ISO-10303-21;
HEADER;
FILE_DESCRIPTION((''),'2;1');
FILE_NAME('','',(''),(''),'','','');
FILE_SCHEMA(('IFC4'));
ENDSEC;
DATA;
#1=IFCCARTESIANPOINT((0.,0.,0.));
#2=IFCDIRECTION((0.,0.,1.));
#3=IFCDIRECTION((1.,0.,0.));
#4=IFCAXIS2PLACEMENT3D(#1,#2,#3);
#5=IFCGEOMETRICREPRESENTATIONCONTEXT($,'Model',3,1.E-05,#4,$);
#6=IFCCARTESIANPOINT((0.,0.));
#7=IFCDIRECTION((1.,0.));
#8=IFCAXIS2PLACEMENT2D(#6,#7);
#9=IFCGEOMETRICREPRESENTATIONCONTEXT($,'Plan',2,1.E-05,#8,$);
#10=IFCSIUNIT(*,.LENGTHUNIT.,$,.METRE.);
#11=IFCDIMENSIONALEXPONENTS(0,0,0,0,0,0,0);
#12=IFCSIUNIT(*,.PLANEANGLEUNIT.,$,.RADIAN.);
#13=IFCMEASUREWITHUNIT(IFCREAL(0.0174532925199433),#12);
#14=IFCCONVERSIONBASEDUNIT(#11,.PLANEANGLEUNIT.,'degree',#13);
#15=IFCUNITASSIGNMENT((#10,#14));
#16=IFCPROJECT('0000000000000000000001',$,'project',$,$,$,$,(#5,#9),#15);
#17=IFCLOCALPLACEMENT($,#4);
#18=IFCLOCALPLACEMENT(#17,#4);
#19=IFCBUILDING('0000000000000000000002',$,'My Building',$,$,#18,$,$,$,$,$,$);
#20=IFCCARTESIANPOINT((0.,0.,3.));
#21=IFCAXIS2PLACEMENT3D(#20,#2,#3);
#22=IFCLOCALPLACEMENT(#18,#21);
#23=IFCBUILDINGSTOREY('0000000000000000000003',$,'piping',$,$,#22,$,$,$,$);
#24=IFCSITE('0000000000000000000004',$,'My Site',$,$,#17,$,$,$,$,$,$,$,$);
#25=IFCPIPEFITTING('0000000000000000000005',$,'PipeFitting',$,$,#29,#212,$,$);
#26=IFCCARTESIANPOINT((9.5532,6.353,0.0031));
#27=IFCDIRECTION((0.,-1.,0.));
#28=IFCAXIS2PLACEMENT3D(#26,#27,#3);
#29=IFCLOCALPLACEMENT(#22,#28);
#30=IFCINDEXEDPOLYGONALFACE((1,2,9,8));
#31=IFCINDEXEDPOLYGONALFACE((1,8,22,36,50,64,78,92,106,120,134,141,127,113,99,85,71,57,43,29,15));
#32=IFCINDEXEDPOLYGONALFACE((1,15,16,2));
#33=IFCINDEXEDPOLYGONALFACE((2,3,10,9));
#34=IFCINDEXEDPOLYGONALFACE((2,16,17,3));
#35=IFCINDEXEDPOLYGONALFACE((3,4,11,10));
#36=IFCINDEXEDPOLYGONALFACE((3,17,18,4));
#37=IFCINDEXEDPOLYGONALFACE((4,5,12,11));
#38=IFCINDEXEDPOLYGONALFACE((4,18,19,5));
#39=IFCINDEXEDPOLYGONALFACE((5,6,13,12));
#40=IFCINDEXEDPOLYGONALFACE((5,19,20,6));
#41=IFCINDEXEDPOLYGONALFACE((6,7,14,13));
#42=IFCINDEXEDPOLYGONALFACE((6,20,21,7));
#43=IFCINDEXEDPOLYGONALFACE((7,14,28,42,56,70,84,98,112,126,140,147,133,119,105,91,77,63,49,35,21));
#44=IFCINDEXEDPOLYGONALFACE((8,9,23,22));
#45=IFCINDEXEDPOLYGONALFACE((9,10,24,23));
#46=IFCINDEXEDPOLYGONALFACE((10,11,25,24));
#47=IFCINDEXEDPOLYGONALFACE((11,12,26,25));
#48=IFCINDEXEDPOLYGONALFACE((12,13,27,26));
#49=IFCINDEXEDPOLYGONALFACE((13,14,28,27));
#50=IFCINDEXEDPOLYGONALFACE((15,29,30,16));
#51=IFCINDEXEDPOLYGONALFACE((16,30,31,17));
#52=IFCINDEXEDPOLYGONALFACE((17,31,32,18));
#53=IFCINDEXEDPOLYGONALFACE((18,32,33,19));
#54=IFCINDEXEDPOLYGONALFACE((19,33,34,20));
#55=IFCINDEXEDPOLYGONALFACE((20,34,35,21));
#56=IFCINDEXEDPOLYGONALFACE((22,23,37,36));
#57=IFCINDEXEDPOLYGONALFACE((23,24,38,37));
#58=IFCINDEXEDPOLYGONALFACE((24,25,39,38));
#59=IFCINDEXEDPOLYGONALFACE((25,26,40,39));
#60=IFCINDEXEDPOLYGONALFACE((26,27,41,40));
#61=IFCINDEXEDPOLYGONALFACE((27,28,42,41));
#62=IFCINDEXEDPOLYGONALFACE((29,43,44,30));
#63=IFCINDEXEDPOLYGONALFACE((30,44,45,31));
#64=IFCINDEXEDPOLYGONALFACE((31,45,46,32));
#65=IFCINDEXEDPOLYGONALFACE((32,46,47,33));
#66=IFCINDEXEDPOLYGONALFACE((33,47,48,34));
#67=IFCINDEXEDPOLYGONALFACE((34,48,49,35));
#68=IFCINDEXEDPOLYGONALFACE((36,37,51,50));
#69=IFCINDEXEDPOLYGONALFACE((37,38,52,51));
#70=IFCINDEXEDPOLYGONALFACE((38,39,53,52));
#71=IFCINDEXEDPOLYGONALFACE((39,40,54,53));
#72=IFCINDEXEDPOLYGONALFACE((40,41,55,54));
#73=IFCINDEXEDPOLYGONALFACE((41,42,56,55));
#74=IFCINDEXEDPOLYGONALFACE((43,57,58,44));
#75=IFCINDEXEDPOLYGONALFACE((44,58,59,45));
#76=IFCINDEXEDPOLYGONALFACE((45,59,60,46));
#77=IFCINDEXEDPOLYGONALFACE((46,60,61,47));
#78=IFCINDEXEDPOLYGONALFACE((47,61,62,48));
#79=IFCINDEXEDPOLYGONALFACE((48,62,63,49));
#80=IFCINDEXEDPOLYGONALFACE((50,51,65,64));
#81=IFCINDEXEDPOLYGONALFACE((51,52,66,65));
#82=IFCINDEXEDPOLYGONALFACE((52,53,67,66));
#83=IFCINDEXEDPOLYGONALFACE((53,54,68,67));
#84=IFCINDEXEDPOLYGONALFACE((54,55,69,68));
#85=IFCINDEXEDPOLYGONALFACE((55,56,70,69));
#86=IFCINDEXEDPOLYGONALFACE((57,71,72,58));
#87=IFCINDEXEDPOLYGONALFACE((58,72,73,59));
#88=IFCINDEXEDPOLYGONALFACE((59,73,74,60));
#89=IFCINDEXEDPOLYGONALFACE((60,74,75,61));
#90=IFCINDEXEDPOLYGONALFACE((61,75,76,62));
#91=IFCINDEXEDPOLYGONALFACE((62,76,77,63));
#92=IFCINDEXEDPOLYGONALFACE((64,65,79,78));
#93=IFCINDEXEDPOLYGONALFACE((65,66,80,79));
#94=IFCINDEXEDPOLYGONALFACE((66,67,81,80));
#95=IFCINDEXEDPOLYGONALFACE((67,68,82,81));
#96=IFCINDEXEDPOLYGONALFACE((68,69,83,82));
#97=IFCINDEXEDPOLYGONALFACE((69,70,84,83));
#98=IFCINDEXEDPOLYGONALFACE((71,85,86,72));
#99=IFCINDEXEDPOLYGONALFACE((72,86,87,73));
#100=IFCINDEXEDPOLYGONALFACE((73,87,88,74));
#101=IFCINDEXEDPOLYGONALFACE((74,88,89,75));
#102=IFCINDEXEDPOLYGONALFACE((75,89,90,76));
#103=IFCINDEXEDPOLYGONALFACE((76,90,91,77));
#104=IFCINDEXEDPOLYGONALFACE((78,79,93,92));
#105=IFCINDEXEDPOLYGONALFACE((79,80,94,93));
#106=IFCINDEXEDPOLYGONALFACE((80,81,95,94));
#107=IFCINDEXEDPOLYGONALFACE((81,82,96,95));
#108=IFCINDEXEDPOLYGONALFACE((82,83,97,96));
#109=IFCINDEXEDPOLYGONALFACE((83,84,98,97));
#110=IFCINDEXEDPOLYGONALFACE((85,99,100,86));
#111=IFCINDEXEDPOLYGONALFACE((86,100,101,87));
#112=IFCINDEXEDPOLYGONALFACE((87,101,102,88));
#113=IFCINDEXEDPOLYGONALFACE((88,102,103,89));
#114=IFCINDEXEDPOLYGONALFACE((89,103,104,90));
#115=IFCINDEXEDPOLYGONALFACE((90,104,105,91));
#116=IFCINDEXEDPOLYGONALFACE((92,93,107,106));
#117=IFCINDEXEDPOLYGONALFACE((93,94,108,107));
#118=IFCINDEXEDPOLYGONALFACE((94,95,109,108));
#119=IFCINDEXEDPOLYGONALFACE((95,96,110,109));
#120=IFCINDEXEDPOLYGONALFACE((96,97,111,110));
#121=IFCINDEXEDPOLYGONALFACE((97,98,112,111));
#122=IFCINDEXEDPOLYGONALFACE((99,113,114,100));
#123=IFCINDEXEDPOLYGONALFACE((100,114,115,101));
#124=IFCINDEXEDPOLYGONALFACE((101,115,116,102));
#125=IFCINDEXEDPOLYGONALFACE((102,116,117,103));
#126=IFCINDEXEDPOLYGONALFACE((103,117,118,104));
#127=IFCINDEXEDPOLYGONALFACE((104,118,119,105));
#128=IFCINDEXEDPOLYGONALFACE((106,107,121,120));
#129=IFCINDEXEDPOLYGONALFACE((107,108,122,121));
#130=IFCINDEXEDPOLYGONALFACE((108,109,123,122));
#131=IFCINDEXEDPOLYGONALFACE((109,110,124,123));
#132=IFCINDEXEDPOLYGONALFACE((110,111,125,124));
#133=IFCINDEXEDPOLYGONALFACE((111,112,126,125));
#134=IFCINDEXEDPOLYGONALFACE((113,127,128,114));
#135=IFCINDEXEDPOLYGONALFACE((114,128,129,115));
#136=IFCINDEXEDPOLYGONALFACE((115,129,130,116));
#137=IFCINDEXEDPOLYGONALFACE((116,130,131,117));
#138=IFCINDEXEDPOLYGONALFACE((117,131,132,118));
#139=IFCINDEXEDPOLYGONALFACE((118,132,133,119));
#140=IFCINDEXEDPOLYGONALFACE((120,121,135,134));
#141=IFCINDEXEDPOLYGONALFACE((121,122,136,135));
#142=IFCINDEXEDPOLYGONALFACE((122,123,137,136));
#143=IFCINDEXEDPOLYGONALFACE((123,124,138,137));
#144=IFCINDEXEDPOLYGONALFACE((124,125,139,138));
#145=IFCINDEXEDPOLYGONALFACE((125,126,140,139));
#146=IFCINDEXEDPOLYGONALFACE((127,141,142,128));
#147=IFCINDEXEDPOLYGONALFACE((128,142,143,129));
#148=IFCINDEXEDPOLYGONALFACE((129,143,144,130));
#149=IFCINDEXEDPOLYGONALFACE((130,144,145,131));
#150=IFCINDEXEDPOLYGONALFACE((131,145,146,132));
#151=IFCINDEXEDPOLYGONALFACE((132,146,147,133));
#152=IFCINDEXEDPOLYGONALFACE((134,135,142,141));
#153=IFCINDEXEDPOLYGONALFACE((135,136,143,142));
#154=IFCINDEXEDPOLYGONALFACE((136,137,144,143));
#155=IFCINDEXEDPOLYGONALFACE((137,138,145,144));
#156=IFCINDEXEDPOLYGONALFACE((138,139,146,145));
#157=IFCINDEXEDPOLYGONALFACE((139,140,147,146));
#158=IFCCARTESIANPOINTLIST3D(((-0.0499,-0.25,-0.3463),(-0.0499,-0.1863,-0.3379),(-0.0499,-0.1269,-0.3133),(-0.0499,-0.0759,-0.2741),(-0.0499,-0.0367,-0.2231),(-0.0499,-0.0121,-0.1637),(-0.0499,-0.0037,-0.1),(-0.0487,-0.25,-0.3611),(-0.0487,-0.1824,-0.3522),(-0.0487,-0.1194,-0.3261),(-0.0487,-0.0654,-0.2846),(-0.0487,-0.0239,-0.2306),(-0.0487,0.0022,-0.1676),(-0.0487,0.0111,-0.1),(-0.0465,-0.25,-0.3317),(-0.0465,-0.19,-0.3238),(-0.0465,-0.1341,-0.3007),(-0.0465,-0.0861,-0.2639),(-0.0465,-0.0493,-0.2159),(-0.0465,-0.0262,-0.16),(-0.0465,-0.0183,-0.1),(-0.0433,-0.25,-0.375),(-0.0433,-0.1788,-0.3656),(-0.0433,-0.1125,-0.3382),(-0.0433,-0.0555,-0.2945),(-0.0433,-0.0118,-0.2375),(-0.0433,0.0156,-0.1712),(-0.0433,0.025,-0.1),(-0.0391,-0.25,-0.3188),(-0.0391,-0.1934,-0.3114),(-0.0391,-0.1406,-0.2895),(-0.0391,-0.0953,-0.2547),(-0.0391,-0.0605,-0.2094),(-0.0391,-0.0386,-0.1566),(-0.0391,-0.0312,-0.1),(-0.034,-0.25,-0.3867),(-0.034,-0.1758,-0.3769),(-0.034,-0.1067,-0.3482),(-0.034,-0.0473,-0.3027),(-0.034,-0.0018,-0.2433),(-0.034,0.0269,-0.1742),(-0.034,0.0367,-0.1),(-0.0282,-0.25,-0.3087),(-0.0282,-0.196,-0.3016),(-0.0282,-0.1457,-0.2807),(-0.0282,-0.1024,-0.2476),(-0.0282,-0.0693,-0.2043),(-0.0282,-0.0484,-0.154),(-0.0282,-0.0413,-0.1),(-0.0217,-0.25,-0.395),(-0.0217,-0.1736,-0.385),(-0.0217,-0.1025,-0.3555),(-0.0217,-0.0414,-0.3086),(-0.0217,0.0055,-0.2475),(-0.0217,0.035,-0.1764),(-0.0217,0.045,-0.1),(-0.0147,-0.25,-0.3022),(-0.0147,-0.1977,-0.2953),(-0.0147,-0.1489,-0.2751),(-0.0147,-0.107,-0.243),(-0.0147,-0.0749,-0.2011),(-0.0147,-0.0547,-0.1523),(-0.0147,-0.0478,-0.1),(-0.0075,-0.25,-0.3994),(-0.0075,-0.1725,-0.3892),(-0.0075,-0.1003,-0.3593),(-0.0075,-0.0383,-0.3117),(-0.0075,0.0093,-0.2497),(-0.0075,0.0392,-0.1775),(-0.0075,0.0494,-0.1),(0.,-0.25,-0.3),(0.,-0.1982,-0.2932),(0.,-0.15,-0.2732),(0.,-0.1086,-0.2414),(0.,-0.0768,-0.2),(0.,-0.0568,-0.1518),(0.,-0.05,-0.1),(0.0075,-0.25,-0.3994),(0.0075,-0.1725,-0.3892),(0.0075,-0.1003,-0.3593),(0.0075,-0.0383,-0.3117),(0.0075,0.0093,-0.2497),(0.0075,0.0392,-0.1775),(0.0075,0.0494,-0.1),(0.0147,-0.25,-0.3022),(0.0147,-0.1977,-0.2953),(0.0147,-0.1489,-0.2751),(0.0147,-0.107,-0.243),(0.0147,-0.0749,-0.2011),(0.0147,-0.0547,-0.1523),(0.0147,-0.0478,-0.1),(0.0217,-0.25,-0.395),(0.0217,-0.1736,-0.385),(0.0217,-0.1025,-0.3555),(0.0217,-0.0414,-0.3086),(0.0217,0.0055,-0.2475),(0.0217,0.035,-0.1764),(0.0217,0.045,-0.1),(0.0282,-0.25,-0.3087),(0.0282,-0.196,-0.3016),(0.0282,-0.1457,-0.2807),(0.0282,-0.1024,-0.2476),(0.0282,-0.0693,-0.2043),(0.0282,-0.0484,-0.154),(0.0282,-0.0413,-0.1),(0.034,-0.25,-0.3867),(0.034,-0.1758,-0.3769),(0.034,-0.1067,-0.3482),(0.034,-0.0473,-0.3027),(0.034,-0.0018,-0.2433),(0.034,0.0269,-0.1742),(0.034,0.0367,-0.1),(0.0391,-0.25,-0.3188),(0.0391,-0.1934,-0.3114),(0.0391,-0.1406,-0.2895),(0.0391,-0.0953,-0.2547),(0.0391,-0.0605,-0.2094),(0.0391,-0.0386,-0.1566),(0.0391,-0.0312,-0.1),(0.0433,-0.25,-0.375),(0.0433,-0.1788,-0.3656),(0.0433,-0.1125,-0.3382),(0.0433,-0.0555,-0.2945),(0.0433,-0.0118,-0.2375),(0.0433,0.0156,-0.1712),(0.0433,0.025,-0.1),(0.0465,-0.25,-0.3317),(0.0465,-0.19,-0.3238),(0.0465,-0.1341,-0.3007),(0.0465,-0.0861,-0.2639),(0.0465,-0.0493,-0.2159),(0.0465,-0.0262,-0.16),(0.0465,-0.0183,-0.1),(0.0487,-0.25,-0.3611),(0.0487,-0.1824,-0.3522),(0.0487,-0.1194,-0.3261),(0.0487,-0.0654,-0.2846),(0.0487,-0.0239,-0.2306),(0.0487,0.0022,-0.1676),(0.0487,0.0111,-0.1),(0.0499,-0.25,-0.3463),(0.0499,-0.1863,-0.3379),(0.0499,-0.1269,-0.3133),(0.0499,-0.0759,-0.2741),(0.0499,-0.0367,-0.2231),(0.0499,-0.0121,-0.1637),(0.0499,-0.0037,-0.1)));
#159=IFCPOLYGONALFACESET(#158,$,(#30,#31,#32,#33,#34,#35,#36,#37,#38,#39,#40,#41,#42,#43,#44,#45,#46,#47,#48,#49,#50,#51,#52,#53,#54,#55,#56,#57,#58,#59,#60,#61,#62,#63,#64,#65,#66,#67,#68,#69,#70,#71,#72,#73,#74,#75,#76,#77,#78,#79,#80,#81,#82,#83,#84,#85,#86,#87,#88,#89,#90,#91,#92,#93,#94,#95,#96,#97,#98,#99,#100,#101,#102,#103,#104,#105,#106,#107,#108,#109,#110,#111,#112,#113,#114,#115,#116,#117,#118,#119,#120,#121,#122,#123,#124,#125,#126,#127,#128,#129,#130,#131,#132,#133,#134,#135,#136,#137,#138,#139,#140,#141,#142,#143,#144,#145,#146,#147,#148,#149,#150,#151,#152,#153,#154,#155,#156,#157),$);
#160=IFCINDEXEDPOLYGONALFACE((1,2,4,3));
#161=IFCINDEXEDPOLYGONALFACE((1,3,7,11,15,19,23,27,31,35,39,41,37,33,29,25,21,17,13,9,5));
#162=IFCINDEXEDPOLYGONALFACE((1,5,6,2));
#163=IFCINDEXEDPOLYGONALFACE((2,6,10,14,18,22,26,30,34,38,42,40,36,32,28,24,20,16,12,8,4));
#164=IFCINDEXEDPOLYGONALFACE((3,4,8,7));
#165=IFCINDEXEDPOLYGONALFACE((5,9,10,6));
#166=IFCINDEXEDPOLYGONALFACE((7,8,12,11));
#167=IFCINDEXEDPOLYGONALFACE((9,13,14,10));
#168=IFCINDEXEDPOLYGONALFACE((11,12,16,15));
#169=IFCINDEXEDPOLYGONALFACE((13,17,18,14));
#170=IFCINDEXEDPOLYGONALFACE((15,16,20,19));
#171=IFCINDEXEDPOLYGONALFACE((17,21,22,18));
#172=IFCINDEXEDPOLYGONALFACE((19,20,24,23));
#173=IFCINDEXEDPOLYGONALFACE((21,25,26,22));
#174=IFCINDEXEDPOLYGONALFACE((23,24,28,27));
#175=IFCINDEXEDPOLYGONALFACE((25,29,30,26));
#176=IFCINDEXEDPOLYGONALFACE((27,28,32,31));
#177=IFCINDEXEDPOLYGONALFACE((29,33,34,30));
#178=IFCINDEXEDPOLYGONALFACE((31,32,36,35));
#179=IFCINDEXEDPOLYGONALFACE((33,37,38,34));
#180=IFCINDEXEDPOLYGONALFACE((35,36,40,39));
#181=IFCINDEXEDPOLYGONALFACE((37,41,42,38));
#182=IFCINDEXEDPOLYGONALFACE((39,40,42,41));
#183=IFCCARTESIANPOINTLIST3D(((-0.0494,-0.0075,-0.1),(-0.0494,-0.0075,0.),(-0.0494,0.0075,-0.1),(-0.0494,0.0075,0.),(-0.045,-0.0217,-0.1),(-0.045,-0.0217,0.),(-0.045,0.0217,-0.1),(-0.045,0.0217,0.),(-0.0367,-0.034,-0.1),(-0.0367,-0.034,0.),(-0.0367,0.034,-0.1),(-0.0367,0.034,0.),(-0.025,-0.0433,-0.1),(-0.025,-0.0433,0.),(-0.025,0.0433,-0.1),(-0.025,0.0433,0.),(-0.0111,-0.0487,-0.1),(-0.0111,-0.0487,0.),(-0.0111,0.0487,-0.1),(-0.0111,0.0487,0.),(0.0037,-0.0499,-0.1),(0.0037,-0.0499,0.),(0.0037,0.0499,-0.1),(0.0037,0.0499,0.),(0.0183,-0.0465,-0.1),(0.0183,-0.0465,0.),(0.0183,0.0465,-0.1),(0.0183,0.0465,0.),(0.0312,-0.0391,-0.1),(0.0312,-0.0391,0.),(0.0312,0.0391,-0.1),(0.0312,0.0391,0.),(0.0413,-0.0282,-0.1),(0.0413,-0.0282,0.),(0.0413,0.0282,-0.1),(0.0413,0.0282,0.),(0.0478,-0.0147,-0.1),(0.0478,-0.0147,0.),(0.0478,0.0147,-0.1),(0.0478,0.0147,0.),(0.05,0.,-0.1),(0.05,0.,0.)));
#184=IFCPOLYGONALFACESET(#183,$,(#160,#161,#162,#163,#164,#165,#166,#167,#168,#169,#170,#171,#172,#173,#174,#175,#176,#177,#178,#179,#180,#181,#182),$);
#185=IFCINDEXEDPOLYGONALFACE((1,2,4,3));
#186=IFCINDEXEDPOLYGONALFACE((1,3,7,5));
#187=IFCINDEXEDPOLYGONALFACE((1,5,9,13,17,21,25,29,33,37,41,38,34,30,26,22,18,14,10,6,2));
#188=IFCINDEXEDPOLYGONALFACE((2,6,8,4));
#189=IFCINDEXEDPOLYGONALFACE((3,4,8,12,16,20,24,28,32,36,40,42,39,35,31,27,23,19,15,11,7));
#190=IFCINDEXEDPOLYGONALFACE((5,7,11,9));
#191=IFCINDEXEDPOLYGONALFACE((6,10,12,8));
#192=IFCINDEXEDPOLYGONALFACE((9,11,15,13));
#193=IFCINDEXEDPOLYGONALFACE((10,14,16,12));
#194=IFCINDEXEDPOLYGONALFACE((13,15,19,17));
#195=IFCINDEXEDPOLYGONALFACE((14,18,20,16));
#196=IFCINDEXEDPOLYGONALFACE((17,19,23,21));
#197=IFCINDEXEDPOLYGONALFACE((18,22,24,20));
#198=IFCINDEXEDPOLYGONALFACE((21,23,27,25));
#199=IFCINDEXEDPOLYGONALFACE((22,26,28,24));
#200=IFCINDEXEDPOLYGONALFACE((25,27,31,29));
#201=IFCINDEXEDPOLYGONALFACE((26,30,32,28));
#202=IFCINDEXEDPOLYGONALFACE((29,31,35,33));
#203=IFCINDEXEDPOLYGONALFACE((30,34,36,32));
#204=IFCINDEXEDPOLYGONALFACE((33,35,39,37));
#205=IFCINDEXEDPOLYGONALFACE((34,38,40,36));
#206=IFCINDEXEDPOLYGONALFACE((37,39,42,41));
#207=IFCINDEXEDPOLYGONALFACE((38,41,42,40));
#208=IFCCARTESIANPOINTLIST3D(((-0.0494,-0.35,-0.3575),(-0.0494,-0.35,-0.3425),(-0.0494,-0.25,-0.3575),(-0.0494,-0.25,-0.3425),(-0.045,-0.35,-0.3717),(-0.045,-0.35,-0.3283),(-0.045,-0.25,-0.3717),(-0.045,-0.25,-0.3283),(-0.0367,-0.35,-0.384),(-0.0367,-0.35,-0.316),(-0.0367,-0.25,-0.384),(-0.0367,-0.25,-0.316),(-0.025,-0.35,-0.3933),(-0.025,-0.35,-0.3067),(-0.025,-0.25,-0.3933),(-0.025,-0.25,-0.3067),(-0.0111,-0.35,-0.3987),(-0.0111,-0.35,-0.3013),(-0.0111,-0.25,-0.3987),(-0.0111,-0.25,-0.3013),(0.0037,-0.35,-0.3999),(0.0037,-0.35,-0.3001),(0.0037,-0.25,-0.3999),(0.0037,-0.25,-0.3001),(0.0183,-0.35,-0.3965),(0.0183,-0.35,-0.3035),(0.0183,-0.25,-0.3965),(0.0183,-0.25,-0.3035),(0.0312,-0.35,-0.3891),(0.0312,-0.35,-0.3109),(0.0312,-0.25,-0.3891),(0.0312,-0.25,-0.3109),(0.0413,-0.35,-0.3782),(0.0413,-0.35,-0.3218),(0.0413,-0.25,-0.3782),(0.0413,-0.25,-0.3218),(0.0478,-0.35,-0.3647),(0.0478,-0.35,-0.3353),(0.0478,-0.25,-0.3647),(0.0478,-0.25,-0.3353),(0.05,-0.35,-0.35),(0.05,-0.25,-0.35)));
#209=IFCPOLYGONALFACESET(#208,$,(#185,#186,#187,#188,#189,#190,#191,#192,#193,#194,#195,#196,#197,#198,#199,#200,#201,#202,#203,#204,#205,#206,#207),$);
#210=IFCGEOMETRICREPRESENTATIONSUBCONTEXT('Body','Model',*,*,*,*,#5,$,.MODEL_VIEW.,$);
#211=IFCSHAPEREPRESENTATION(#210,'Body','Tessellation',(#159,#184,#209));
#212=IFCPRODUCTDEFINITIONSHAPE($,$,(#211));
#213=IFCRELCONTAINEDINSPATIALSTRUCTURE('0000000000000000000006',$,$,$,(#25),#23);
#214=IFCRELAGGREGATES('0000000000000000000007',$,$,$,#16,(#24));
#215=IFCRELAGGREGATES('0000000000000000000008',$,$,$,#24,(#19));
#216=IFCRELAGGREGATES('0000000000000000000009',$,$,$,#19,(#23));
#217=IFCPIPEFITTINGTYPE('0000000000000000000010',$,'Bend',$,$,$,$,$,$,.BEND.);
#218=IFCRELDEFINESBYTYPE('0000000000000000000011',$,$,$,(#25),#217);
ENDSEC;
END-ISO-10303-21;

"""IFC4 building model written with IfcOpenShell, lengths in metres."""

from ifc_helpers import new_model, entity, si_unit, converted_unit, frame, origin_with_axes, origin_2d_with_axis, place, context, subcontext, project, spatial, circle, extrude, source, transform, mapped, type_object, type_shapes, element, save


model = new_model("IFC4")

# Units and contexts
model_context = context("Model", 3, precision=1e-05, world=origin_with_axes())
plan_context = context("Plan", 2, precision=1e-05, world=origin_2d_with_axis())
body_context = subcontext(model_context, "Body", "Model", "MODEL_VIEW")
ifc_project = project(units=[si_unit("LENGTHUNIT", "METRE"), converted_unit("PLANEANGLEUNIT", "degree", entity("IfcReal", 0.0174532925199433), si_unit("PLANEANGLEUNIT", "RADIAN"), dimensions=[0, 0, 0, 0, 0, 0, 0])], contexts=[model_context, plan_context])

# Site, building, storey
site_placement = place(None, origin_with_axes())
site = spatial("IfcSite", under=ifc_project, at=site_placement, Name="My Site")
building_placement = place(site_placement, origin_with_axes())
building = spatial("IfcBuilding", under=site, at=building_placement, Name="My Building")
storey_placement = place(building_placement, frame((0.0, 0.0, 3.0), z_axis=(0.0, 0.0, 1.0), x_axis=(1.0, 0.0, 0.0)))
storey = spatial("IfcBuildingStorey", under=building, at=storey_placement, Name="piping")

# Pipe fitting
pipe_fitting_type = type_object("IfcPipeFittingType", Name="Bend", PredefinedType="BEND")
shared_shape = source(origin_with_axes(), body_context, "Body", "SolidModel", [
    entity("IfcSweptDiskSolid", entity("IfcIndexedPolyCurve", entity("IfcCartesianPointList3D", [[0.0, 0.0, -0.1], [0.0, -0.0732, -0.2768], [0.0, -0.25, -0.35]]), [entity("IfcArcIndex", [1, 2, 3])]), 0.05),
    extrude(circle(Radius=0.05), origin_with_axes(), (0.0, 0.0, -1.0), 0.1),
    extrude(circle(Radius=0.05), frame((0.0, -0.25, -0.35), z_axis=(0.0, -1.0, 0.0), x_axis=(1.0, 0.0, 0.0)), (0.0, 0.0, 1.0), 0.1),
])
type_shapes(pipe_fitting_type, [shared_shape])
for number, where, z_axis, x_axis, name in (
    (1, (9.5532, 6.353, 0.0031), (0.0, -1.0, 0.0), (1.0, 0.0, 0.0), "PipeFitting"),
):
    element("IfcPipeFitting", number, at=place(storey_placement, frame(where, z_axis=z_axis, x_axis=x_axis)), inside=storey, type_object=pipe_fitting_type, Name=name, context=body_context, shape_type="MappedRepresentation", body=[
        mapped(shared_shape, transform((0.0, 0.0, 0.0), x_axis=(1.0, 0.0, 0.0), y_axis=(0.0, 1.0, 0.0), z_axis=(0.0, 0.0, 1.0), scale=1.0)),
    ])

save(model, "model.ifc")
